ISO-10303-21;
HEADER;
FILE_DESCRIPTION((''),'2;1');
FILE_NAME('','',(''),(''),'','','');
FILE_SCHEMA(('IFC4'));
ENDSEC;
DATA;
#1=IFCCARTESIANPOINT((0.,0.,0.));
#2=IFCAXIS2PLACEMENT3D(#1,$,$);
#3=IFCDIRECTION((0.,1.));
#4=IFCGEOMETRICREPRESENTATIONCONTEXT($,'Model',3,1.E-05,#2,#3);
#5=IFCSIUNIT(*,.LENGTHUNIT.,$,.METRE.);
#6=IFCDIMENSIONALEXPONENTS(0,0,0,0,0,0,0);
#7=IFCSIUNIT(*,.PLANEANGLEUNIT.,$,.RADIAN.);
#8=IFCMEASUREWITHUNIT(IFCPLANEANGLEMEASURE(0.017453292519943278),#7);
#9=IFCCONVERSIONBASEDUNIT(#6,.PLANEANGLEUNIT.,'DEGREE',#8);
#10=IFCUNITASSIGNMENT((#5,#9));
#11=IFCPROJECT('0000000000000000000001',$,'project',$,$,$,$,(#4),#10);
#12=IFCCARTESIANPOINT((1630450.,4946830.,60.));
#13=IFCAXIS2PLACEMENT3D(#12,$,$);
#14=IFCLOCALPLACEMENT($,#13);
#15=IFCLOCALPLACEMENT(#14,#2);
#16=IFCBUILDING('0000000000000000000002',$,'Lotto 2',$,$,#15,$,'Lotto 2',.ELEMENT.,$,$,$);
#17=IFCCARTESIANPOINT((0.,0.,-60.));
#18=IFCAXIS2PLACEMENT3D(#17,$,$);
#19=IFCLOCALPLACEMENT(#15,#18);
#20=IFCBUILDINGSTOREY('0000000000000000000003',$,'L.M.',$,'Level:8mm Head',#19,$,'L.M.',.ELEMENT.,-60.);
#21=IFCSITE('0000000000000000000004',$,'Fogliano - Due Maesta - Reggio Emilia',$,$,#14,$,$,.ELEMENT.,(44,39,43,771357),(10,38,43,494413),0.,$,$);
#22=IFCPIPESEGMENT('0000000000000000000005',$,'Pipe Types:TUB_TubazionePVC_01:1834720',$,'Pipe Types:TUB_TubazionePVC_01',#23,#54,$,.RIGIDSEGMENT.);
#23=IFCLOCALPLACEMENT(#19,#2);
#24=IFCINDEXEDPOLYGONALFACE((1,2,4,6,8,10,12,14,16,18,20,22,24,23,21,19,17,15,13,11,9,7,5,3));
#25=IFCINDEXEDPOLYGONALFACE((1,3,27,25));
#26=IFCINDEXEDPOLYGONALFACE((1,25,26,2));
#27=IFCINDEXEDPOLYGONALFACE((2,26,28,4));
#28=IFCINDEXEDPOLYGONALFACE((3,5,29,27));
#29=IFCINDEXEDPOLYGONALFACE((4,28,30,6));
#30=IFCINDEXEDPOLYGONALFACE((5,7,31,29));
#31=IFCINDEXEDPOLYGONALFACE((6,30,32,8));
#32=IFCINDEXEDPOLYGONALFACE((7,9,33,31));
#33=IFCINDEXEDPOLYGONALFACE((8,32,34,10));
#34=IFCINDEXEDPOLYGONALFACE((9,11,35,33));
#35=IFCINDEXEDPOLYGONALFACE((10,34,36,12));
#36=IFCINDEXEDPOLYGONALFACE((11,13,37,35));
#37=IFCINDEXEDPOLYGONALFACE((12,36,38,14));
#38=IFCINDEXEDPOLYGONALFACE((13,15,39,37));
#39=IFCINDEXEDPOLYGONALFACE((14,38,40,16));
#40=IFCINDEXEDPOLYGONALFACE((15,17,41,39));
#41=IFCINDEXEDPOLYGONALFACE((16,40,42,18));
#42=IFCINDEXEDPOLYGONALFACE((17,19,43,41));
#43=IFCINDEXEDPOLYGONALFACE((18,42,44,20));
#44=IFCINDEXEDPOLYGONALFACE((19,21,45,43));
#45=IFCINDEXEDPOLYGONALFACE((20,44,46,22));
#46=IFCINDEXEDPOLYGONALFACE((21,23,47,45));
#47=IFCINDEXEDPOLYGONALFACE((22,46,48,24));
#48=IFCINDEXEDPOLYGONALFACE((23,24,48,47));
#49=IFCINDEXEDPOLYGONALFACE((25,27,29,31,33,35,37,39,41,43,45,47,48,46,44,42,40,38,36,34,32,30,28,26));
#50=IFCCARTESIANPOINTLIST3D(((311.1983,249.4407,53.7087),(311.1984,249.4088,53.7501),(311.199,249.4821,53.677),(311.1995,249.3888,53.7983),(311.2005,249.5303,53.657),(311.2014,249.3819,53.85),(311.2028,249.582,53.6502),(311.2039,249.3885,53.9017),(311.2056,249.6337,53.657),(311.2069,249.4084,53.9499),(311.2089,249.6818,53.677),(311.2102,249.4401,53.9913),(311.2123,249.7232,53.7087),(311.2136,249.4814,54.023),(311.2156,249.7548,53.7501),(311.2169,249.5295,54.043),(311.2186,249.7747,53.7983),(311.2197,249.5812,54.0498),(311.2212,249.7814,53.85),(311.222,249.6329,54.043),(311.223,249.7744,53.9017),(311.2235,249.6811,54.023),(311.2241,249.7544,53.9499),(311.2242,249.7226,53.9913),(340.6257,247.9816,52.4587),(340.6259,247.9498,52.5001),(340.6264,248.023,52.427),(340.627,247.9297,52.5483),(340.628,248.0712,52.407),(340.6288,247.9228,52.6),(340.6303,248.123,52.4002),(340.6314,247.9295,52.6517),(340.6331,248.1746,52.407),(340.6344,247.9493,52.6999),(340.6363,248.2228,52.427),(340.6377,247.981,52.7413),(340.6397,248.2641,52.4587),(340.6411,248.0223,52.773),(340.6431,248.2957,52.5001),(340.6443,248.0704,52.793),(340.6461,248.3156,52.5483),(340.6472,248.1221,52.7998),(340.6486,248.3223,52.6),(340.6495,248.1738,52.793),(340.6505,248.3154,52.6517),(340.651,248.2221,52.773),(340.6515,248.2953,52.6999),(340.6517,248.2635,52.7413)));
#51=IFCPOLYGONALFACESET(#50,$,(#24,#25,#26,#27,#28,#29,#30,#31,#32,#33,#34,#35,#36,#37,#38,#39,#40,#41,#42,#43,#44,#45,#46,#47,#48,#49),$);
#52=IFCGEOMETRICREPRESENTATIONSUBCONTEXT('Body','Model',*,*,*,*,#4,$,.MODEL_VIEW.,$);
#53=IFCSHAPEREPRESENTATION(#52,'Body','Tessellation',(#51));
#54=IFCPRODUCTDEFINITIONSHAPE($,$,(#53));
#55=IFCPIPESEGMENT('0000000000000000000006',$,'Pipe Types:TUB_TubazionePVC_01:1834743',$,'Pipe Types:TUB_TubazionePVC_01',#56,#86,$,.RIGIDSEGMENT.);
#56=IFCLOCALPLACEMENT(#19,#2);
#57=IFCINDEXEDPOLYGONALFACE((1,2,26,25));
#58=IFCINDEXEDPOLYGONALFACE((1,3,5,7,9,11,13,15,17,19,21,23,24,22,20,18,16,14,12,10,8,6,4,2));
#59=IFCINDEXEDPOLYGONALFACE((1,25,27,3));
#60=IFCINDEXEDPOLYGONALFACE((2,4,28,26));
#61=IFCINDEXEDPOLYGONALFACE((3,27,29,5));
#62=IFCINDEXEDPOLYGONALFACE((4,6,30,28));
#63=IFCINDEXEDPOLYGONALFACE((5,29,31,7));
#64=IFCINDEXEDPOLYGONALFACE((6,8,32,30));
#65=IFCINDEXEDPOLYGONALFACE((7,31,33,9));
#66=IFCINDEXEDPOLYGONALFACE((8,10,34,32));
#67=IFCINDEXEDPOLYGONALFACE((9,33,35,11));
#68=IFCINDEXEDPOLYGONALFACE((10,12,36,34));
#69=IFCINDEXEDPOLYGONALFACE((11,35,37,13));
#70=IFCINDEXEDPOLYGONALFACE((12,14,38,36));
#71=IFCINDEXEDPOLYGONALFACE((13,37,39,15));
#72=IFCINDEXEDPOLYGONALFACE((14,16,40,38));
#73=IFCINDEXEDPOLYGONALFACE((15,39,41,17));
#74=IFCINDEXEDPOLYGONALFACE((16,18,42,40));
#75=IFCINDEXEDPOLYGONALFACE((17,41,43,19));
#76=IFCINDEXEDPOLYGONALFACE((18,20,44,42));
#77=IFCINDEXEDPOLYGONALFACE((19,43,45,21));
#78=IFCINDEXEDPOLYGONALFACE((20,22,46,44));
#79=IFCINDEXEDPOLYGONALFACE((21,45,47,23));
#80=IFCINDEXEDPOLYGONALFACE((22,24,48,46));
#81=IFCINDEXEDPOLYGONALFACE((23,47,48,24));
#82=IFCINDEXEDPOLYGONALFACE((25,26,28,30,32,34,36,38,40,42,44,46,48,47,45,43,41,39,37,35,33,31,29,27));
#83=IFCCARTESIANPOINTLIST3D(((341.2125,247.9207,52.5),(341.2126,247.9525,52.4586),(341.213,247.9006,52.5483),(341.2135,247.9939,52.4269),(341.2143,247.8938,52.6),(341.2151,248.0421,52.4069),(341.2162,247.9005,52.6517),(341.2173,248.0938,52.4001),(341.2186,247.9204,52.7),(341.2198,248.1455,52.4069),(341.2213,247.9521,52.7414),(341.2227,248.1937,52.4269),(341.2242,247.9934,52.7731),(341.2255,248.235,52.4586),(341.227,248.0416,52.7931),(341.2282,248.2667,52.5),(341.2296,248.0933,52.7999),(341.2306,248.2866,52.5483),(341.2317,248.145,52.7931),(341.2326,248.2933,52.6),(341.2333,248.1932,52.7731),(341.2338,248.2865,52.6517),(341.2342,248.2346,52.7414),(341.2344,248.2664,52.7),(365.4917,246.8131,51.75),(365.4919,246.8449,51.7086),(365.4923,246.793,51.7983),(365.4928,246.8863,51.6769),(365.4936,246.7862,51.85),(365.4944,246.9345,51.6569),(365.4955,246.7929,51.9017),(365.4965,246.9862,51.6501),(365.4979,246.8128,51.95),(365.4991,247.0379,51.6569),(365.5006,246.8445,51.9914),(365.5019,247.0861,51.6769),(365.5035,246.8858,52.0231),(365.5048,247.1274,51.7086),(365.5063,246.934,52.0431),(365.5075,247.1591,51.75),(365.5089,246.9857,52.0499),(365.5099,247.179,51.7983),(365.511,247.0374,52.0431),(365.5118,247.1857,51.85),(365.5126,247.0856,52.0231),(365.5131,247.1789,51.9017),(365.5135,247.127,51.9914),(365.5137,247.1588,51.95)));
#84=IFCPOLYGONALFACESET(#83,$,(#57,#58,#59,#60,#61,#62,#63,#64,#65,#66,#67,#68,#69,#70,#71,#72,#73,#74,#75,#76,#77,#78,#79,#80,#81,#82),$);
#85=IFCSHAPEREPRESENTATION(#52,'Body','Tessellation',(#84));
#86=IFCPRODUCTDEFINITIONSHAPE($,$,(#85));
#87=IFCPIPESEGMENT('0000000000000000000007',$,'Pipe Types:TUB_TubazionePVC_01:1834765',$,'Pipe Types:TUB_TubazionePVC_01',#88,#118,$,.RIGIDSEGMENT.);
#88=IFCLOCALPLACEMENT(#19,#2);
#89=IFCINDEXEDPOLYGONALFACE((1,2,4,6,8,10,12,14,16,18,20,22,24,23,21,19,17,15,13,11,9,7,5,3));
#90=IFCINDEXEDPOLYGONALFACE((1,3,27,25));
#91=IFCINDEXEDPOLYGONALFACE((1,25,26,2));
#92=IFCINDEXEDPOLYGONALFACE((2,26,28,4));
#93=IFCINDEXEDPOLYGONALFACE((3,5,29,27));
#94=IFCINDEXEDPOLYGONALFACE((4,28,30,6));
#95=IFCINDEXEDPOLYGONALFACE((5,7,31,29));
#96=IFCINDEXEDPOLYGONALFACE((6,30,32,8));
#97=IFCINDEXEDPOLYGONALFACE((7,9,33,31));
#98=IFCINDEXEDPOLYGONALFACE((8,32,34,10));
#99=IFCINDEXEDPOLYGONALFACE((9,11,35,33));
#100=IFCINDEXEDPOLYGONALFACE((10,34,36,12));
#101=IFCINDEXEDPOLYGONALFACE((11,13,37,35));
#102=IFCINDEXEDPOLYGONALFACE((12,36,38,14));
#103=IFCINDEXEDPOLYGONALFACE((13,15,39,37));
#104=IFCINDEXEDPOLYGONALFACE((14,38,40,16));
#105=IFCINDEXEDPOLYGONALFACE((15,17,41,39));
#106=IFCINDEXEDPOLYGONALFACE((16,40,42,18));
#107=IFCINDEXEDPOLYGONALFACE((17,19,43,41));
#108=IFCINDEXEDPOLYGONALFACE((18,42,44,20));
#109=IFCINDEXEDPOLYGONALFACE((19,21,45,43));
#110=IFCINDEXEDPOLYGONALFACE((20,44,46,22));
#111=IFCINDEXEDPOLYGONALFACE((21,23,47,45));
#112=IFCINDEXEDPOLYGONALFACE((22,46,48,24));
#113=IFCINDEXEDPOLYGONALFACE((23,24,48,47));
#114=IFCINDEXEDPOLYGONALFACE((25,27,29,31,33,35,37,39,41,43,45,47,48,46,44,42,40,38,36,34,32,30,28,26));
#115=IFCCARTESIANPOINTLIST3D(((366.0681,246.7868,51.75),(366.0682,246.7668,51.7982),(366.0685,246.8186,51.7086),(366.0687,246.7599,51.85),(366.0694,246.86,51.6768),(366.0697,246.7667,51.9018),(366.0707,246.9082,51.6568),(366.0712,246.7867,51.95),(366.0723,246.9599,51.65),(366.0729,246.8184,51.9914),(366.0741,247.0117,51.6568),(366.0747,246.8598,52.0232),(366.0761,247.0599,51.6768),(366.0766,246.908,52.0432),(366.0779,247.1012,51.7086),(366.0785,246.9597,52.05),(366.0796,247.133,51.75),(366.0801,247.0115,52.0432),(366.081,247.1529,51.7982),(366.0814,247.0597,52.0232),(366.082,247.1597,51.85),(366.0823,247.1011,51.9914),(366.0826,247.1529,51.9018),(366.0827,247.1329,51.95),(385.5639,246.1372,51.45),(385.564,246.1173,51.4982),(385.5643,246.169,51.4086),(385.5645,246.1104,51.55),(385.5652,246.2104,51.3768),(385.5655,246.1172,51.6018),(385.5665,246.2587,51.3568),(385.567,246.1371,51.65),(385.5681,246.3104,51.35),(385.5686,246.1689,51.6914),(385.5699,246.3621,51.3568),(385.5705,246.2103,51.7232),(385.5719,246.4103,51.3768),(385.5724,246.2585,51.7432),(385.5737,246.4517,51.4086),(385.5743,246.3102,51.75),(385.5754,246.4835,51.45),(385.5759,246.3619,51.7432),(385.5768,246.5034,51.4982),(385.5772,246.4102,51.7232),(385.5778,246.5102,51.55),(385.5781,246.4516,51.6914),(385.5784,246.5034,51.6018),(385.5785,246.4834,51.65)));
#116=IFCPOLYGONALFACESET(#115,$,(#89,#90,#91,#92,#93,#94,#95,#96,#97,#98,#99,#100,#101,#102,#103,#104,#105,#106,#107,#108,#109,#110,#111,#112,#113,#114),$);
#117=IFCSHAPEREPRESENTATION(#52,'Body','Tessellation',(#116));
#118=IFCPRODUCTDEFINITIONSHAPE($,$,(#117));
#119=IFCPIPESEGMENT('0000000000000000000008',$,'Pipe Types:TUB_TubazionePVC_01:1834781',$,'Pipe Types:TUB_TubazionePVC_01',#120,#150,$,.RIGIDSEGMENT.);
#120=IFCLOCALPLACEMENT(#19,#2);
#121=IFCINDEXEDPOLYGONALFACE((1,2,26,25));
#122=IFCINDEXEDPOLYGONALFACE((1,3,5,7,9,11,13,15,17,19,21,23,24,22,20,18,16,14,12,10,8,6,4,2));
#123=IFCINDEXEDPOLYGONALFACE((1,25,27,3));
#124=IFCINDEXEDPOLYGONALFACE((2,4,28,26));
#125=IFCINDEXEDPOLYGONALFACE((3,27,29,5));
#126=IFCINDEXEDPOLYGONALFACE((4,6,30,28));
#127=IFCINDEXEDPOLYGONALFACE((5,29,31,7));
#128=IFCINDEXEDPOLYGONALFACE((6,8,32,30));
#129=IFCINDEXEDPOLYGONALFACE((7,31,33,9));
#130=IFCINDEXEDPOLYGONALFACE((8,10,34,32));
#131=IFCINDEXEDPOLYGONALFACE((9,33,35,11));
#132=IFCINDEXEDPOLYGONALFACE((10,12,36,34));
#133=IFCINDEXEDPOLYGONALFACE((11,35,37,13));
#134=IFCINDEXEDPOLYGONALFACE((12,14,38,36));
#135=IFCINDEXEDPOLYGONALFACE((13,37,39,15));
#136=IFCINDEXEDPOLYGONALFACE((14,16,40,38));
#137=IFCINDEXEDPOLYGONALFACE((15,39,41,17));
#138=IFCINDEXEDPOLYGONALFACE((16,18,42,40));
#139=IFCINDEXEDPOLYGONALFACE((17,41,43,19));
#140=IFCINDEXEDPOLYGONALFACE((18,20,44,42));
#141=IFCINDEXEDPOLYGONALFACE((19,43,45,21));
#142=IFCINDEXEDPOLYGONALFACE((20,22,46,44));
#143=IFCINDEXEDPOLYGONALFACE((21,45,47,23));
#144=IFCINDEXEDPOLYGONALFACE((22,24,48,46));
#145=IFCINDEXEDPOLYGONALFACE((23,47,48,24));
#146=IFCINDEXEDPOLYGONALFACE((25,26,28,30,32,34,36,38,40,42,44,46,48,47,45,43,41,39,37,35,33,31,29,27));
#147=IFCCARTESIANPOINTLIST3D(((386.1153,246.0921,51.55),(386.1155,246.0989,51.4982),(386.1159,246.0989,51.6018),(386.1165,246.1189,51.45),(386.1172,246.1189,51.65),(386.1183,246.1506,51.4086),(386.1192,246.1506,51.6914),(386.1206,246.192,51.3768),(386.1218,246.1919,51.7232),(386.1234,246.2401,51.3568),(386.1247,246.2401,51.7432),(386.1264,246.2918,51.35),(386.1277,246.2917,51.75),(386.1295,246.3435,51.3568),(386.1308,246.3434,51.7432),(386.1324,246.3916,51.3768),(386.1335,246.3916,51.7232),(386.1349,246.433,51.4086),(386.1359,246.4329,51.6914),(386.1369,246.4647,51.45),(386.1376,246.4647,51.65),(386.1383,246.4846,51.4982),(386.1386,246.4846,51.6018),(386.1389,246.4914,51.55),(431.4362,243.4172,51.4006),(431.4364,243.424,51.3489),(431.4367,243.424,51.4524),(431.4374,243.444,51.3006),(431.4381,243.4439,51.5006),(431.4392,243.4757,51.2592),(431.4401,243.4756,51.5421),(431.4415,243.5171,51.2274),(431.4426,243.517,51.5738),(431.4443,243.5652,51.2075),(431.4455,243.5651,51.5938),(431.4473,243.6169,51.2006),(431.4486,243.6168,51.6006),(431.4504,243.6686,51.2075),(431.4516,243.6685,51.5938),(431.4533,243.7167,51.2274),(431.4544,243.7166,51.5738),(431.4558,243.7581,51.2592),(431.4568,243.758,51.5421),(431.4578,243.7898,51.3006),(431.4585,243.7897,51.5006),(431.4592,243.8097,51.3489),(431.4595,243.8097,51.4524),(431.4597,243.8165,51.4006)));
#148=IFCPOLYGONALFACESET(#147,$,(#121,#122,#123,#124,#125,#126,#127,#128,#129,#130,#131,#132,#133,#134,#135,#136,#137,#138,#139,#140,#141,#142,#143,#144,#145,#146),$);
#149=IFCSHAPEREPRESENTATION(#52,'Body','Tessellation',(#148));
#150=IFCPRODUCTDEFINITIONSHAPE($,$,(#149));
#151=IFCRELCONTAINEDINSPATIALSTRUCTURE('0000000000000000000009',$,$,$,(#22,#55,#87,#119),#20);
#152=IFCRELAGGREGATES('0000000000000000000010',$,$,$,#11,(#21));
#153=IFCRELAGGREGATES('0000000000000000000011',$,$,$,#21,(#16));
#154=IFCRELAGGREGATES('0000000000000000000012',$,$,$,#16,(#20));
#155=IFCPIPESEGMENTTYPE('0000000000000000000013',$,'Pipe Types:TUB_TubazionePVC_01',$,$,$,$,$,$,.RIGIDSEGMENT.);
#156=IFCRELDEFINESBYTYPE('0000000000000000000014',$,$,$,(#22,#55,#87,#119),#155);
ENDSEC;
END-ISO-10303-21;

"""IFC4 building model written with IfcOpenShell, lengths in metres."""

from ifc_helpers import new_model, entity, si_unit, converted_unit, direction, frame, origin, place, context, subcontext, project, spatial, arc, indexed_curve, outline, extrude, type_object, element, save


model = new_model("IFC4")

# Units and contexts
model_context = context("Model", 3, precision=1e-05, world=origin(), true_north=direction((0.0, 1.0)))
body_context = subcontext(model_context, "Body", "Model", "MODEL_VIEW")
ifc_project = project(units=[si_unit("LENGTHUNIT", "METRE"), converted_unit("PLANEANGLEUNIT", "DEGREE", entity("IfcPlaneAngleMeasure", 0.017453292519943278), si_unit("PLANEANGLEUNIT", "RADIAN"), dimensions=[0, 0, 0, 0, 0, 0, 0])], contexts=[model_context])

# Site, building, storey
site_placement = place(None, frame((1630450.0, 4946830.0, 60.0)))
site = spatial("IfcSite", under=ifc_project, at=site_placement, Name="Fogliano - Due Maesta - Reggio Emilia", CompositionType="ELEMENT", RefLatitude=(44, 39, 43, 771357), RefLongitude=(10, 38, 43, 494413), RefElevation=0.0)
building_placement = place(site_placement, origin())
building = spatial("IfcBuilding", under=site, at=building_placement, Name="Lotto 2", LongName="Lotto 2", CompositionType="ELEMENT")
storey_placement = place(building_placement, frame((0.0, 0.0, -60.0)))
storey = spatial("IfcBuildingStorey", under=building, at=storey_placement, Name="L.M.", ObjectType="Level:8mm Head", LongName="L.M.", CompositionType="ELEMENT", Elevation=-60.0)

# Pipe segments
pipe_segment_type = type_object("IfcPipeSegmentType", Name="Pipe Types:TUB_TubazionePVC_01", PredefinedType="RIGIDSEGMENT")
pipe_segment_1_placement = place(storey_placement, origin())
element("IfcPipeSegment", 1, at=pipe_segment_1_placement, inside=storey, type_object=pipe_segment_type, Name="Pipe Types:TUB_TubazionePVC_01:1834720", ObjectType="Pipe Types:TUB_TubazionePVC_01", PredefinedType="RIGIDSEGMENT", context=body_context, shape_type="SweptSolid", body=[
    extrude(outline(indexed_curve([(0.2, 0.0), (0.1414, 0.1414), (0.0, 0.2), (-0.1414, 0.1414), (-0.2, 0.0), (-0.1414, -0.1414), (0.0, -0.2), (0.1414, -0.1414)], segments=[arc(1, 2, 3), arc(3, 4, 5), arc(5, 6, 7), arc(7, 8, 1)], self_intersect=False)), frame((340.6387, 248.1225, 52.6), z_axis=(-0.997875, 0.049476, 0.042387), x_axis=(-0.049521, -0.998773, 0.0)), (0.0, 0.0, 1.0), 29.4901),
])
pipe_segment_2_placement = place(storey_placement, origin())
element("IfcPipeSegment", 2, at=pipe_segment_2_placement, inside=storey, type_object=pipe_segment_type, Name="Pipe Types:TUB_TubazionePVC_01:1834743", ObjectType="Pipe Types:TUB_TubazionePVC_01", PredefinedType="RIGIDSEGMENT", context=body_context, shape_type="SweptSolid", body=[
    extrude(outline(indexed_curve([(0.2, 0.0), (0.1414, 0.1414), (0.0, 0.2), (-0.1414, 0.1414), (-0.2, 0.0), (-0.1414, -0.1414), (0.0, -0.2), (0.1414, -0.1414)], segments=[arc(1, 2, 3), arc(3, 4, 5), arc(5, 6, 7), arc(7, 8, 1)], self_intersect=False)), frame((365.5027, 246.986, 51.85), z_axis=(-0.998486, 0.04555, 0.030844), x_axis=(-0.045572, -0.998961, 0.0)), (0.0, 0.0, 1.0), 24.3161),
])
pipe_segment_3_placement = place(storey_placement, origin())
element("IfcPipeSegment", 3, at=pipe_segment_3_placement, inside=storey, type_object=pipe_segment_type, Name="Pipe Types:TUB_TubazionePVC_01:1834765", ObjectType="Pipe Types:TUB_TubazionePVC_01", PredefinedType="RIGIDSEGMENT", context=body_context, shape_type="SweptSolid", body=[
    extrude(outline(indexed_curve([(0.2, 0.0), (0.1414, 0.1414), (0.0, 0.2), (-0.1414, 0.1414), (-0.2, 0.0), (-0.1414, -0.1414), (0.0, -0.2), (0.1414, -0.1414)], segments=[arc(1, 2, 3), arc(3, 4, 5), arc(5, 6, 7), arc(7, 8, 1)], self_intersect=False)), frame((366.0754, 246.9598, 51.85), z_axis=(0.999327, -0.033294, -0.015378), x_axis=(-0.033297, -0.999445, 0.0)), (0.0, 0.0, 1.0), 19.5089),
])
pipe_segment_4_placement = place(storey_placement, origin())
element("IfcPipeSegment", 4, at=pipe_segment_4_placement, inside=storey, type_object=pipe_segment_type, Name="Pipe Types:TUB_TubazionePVC_01:1834781", ObjectType="Pipe Types:TUB_TubazionePVC_01", PredefinedType="RIGIDSEGMENT", context=body_context, shape_type="SweptSolid", body=[
    extrude(outline(indexed_curve([(0.2, 0.0), (0.1414, 0.1414), (0.0, 0.2), (-0.1414, 0.1414), (-0.2, 0.0), (-0.1414, -0.1414), (0.0, -0.2), (0.1414, -0.1414)], segments=[arc(1, 2, 3), arc(3, 4, 5), arc(5, 6, 7), arc(7, 8, 1)], self_intersect=False)), frame((386.1271, 246.2918, 51.55), z_axis=(0.998257, -0.058919, -0.00329), x_axis=(-0.05892, -0.998263, 0.0)), (0.0, 0.0, 1.0), 45.4),
])

save(model, "model.ifc")
